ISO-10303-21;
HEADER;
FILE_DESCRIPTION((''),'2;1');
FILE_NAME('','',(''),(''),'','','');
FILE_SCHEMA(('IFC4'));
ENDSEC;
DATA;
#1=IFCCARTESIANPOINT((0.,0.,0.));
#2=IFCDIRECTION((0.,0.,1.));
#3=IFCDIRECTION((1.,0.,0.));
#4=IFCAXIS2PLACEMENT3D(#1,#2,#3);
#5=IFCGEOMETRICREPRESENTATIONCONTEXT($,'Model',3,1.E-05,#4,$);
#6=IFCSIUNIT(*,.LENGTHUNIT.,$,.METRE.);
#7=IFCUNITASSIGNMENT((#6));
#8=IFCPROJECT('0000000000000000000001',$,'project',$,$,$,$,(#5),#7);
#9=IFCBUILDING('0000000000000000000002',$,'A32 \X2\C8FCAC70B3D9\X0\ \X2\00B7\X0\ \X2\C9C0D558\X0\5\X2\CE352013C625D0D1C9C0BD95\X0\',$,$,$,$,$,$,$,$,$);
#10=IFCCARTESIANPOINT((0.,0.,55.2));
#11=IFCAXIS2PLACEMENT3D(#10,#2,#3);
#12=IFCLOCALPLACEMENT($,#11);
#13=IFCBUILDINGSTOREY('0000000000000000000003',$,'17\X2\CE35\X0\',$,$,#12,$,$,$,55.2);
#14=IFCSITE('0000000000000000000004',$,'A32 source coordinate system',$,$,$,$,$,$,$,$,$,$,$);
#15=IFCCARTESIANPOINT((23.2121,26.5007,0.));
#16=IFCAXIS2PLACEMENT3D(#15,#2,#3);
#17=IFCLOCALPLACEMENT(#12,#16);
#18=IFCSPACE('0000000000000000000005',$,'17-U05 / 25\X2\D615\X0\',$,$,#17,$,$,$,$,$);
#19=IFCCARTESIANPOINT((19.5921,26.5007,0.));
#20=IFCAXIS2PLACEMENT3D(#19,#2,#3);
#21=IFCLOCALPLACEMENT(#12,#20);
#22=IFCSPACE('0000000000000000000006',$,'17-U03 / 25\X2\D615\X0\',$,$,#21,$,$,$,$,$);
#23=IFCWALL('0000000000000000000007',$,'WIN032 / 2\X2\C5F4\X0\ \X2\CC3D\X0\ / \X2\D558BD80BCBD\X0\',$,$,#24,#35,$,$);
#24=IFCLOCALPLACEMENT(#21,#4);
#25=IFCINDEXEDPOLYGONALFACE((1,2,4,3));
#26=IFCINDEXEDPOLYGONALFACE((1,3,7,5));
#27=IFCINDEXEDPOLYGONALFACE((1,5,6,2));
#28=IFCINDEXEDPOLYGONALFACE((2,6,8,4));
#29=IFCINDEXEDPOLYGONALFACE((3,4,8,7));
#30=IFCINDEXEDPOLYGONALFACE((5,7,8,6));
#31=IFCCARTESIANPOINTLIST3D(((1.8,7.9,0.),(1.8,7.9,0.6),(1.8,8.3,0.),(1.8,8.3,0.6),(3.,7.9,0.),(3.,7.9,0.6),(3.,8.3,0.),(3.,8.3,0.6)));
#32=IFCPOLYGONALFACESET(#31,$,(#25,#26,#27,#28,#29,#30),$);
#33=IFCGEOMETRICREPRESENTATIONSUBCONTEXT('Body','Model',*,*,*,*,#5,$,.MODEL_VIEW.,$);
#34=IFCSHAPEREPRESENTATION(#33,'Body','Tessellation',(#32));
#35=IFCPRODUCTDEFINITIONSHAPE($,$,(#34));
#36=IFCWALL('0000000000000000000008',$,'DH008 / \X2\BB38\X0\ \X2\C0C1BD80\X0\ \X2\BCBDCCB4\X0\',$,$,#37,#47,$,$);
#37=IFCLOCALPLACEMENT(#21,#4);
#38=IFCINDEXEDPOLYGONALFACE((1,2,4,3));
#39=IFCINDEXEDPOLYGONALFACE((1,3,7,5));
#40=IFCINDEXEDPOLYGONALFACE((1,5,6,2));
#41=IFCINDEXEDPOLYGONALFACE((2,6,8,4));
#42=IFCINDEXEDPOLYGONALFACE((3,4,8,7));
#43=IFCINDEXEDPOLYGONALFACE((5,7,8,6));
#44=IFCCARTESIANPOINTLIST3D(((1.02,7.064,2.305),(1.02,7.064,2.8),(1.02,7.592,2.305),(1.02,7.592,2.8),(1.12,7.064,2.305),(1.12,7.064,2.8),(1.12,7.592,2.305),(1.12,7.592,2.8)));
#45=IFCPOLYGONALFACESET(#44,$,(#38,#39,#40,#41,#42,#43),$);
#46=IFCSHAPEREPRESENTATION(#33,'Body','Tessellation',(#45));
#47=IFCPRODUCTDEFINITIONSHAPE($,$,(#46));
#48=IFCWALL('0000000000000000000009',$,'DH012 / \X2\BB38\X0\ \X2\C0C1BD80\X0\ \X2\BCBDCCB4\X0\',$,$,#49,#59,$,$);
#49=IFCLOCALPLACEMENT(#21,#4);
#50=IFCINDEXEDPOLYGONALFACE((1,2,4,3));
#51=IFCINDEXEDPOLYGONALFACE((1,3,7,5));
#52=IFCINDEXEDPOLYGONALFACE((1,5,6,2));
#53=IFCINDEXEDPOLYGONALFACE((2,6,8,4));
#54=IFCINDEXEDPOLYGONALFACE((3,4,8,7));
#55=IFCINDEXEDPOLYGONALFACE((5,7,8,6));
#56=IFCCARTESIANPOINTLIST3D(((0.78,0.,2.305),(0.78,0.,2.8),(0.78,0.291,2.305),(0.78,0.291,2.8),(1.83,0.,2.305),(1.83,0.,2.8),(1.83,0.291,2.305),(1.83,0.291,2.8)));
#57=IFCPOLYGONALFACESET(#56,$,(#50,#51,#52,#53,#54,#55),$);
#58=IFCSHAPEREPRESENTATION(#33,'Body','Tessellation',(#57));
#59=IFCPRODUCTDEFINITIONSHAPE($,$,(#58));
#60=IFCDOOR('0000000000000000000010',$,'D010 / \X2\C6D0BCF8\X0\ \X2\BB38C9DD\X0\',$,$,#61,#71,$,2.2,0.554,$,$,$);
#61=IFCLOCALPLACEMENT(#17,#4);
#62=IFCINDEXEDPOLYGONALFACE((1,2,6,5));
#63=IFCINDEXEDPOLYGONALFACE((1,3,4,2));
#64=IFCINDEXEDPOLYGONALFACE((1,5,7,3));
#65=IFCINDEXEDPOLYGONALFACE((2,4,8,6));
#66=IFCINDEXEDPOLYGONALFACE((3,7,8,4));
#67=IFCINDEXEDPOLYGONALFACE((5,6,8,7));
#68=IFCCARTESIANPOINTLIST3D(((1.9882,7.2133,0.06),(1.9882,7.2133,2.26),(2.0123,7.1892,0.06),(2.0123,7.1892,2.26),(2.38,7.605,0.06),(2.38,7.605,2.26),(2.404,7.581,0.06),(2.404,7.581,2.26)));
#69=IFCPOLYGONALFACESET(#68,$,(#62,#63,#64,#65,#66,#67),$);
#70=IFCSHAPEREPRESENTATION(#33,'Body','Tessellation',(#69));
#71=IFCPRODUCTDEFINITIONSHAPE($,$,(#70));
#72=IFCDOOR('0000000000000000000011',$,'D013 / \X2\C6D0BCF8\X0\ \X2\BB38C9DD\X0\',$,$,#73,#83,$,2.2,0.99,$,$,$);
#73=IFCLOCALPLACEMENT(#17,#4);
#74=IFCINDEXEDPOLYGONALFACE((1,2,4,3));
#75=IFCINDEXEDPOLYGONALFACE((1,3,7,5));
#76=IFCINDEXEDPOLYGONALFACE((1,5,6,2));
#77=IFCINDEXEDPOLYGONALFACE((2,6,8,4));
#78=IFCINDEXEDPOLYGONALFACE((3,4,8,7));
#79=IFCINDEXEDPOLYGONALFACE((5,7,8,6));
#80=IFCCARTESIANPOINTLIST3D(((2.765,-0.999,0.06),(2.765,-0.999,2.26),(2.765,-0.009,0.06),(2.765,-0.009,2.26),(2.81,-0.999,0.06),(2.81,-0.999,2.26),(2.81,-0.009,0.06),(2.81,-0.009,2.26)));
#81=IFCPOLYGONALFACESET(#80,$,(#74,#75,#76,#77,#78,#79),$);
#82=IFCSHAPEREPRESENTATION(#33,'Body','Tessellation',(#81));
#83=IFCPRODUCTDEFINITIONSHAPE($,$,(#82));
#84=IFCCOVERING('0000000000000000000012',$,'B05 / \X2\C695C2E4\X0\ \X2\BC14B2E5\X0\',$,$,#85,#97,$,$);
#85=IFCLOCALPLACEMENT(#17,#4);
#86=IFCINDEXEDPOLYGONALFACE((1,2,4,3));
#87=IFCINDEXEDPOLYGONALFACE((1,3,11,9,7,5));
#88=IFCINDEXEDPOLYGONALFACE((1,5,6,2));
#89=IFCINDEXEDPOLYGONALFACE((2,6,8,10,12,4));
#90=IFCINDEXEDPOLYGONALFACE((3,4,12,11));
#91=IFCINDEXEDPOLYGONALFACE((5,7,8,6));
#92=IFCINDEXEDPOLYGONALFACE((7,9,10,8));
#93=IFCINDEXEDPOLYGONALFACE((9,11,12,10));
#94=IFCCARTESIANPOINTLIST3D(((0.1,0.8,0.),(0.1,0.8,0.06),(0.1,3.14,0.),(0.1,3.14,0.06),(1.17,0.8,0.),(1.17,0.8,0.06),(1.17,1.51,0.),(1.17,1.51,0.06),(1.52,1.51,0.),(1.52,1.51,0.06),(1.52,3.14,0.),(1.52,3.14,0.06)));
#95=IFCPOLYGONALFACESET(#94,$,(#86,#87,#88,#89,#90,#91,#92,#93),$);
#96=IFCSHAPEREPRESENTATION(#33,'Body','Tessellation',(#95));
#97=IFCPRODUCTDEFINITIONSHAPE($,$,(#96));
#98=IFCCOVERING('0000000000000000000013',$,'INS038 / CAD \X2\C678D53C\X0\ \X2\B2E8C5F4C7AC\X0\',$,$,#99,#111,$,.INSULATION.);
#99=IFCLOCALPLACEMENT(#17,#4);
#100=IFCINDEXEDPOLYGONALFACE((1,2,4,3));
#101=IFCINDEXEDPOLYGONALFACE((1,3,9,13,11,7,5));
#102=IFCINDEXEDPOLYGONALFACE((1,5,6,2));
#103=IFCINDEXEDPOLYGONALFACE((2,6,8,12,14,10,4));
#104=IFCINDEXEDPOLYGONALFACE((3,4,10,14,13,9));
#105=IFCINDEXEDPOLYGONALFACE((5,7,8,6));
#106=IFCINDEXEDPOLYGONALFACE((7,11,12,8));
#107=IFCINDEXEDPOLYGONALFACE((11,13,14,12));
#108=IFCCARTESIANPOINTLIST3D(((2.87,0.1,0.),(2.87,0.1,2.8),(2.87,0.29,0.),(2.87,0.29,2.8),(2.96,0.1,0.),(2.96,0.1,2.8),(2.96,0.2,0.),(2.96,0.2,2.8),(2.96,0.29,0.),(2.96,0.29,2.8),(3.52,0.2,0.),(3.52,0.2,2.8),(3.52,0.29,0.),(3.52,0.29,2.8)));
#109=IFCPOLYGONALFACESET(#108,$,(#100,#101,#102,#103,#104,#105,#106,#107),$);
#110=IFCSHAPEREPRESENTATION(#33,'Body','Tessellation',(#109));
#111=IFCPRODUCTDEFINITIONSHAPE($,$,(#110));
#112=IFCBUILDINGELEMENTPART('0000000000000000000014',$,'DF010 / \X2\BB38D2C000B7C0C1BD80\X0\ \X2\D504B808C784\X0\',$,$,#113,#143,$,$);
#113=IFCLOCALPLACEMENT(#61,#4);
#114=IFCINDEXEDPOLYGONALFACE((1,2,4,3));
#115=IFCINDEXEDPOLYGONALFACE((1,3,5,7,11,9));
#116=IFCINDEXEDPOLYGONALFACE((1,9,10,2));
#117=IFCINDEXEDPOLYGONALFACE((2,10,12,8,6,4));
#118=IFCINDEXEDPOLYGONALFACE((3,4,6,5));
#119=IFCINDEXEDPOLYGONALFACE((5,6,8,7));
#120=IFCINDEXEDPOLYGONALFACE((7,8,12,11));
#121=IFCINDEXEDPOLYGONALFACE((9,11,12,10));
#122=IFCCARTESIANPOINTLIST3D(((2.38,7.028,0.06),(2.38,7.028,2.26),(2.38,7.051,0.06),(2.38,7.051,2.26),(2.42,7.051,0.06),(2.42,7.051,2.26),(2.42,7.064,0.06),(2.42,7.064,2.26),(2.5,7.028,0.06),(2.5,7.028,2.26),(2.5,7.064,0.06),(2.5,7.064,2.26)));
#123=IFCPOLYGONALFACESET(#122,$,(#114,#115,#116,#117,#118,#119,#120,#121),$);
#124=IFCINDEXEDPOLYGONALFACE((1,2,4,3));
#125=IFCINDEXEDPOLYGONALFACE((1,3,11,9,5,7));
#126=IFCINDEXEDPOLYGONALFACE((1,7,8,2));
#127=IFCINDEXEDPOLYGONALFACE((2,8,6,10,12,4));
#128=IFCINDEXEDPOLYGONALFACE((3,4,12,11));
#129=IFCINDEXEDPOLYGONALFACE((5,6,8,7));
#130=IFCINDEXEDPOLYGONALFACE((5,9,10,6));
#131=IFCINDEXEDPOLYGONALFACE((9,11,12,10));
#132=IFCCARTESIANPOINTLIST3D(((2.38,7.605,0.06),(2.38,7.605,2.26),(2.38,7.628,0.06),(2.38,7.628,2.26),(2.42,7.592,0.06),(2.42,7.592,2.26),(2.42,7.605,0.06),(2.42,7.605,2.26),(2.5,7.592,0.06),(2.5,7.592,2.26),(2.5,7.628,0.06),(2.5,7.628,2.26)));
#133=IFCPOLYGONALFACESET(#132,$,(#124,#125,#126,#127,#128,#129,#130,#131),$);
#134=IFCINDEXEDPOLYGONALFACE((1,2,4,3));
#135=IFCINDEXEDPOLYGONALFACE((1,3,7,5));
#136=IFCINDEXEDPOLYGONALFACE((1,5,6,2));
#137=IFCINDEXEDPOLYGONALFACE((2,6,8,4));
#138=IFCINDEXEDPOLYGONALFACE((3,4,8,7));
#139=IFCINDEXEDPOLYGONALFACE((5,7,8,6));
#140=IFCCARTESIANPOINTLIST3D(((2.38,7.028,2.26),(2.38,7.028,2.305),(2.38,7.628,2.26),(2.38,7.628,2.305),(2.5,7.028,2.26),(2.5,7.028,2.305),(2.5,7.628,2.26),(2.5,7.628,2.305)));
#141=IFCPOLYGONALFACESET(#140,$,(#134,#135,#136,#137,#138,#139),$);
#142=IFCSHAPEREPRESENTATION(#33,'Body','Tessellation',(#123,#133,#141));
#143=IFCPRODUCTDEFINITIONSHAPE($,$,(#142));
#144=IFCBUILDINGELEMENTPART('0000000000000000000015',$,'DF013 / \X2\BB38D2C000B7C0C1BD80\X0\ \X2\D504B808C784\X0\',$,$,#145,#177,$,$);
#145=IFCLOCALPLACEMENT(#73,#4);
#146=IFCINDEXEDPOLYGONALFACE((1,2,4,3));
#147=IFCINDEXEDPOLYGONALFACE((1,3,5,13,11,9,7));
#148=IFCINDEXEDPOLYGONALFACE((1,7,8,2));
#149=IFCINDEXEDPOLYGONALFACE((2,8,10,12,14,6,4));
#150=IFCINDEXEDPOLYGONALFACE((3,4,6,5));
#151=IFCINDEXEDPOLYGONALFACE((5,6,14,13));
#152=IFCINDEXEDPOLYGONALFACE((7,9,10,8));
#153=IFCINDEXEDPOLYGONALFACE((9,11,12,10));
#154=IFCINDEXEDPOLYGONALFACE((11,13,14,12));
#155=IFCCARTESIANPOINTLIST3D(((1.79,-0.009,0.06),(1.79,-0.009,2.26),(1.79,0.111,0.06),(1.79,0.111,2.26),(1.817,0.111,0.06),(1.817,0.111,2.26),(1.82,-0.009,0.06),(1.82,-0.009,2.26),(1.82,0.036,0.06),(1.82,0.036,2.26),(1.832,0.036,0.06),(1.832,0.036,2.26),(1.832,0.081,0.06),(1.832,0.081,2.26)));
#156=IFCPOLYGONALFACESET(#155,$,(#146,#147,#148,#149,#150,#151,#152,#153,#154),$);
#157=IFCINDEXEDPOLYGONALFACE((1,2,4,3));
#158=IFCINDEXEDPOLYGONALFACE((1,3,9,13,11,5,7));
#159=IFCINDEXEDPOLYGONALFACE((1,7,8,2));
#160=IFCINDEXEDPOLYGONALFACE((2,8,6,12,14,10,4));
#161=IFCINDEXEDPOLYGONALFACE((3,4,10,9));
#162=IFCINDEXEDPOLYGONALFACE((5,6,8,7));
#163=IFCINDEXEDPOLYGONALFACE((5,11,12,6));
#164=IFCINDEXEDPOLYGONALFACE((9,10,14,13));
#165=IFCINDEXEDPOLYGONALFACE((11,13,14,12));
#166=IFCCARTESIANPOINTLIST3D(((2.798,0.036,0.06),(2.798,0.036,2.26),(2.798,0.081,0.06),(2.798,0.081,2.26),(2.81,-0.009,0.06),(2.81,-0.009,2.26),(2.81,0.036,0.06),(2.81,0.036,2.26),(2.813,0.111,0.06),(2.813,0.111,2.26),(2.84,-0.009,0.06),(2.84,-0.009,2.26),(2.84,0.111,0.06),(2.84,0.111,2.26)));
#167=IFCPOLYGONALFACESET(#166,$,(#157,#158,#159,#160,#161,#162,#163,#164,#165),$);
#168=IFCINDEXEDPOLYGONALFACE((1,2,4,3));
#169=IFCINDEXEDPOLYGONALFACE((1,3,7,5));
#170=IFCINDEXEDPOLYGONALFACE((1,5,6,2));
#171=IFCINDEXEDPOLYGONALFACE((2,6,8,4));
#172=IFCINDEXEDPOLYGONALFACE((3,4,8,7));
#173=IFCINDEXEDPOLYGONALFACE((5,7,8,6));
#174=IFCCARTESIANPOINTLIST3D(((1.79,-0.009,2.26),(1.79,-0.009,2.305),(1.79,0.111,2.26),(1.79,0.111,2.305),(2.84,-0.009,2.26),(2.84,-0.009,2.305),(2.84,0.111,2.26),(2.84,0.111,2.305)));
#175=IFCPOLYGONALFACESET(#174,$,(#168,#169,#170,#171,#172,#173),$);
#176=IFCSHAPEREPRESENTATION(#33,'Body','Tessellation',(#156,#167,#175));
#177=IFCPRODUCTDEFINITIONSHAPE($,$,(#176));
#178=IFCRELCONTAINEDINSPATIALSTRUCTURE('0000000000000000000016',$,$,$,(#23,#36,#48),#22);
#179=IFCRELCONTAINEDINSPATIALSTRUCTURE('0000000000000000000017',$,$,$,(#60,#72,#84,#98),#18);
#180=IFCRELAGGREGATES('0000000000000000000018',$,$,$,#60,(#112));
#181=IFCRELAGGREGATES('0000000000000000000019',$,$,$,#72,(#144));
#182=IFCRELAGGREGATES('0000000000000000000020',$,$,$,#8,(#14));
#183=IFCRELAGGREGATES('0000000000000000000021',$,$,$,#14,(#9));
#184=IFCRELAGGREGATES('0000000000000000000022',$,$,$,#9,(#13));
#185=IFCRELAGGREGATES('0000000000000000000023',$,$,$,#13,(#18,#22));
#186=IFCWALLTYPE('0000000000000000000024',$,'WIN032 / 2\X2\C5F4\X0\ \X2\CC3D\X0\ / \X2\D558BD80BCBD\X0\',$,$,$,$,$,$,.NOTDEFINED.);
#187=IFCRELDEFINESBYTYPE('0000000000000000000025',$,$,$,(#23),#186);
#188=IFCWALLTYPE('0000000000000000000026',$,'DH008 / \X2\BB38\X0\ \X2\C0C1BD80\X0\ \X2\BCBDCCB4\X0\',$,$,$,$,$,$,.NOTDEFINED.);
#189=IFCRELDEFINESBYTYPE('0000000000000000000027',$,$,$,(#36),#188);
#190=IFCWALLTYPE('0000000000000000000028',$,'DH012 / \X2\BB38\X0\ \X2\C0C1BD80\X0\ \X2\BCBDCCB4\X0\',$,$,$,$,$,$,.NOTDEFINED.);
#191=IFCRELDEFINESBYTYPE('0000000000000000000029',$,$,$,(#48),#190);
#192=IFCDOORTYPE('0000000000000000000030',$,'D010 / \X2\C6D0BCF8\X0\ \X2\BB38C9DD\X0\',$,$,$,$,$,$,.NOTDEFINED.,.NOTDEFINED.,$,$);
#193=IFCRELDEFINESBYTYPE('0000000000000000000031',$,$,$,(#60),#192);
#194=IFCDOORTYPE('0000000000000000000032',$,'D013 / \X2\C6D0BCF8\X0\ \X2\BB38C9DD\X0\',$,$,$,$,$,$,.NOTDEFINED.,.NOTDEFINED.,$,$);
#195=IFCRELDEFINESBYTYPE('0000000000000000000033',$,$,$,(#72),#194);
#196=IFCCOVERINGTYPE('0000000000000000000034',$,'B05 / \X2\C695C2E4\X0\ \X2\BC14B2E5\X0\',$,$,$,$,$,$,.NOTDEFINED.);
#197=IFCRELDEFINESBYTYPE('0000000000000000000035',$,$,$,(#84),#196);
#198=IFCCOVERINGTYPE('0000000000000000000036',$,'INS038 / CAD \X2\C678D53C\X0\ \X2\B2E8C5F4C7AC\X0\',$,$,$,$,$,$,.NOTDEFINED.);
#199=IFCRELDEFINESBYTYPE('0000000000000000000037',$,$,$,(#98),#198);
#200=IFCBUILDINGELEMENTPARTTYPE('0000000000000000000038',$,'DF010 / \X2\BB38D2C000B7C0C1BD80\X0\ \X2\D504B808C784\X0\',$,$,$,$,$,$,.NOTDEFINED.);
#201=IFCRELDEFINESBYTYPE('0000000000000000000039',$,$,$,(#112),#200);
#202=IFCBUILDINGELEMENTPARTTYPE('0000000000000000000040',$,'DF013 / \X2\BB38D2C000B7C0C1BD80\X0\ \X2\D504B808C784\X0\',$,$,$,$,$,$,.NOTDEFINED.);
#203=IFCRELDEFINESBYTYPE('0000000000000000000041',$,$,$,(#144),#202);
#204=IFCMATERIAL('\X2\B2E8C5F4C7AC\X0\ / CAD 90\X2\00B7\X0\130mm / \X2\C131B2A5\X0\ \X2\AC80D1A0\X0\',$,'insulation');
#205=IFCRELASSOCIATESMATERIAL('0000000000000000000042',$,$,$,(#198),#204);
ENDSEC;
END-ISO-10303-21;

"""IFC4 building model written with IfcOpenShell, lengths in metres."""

from ifc_helpers import new_model, si_unit, frame, origin, origin_with_axes, place, context, subcontext, project, spatial, polyline, outline, extrude, source, transform, mapped, material, type_object, type_shapes, element, aggregate, save


model = new_model("IFC4")

# Units and contexts
model_context = context("Model", 3, precision=1e-05, world=origin_with_axes())
body_context = subcontext(model_context, "Body", "Model", "MODEL_VIEW")
ifc_project = project(units=[si_unit("LENGTHUNIT", "METRE")], contexts=[model_context])

# Site, building, storey, space
storey_placement = place(None, frame((0.0, 0.0, 55.2), z_axis=(0.0, 0.0, 1.0), x_axis=(1.0, 0.0, 0.0)))
space_1_placement = place(storey_placement, frame((23.2121, 26.5007, 0.0), z_axis=(0.0, 0.0, 1.0), x_axis=(1.0, 0.0, 0.0)))
site = spatial("IfcSite", under=ifc_project, Name="A32 source coordinate system")
building = spatial("IfcBuilding", under=site, Name="A32 주거동 · 지하5층–옥탑지붕")
storey = spatial("IfcBuildingStorey", under=building, at=storey_placement, Name="17층", Elevation=55.2)
space_1 = spatial("IfcSpace", under=storey, at=space_1_placement, Name="17-U05 / 25형")

# Shared definitions
space_2_placement = place(storey_placement, frame((19.5921, 26.5007, 0.0), z_axis=(0.0, 0.0, 1.0), x_axis=(1.0, 0.0, 0.0)))
space_2 = spatial("IfcSpace", under=storey, at=space_2_placement, Name="17-U03 / 25형")

# Walls
wall_type_1 = type_object("IfcWallType", Name="WIN032 / 2열 창 / 하부벽", PredefinedType="NOTDEFINED")
shared_shape_1 = source(origin(), body_context, "Body", "SweptSolid", [
    extrude(outline(polyline([(3.0, 7.9), (1.8, 7.9), (1.8, 8.3), (3.0, 8.3), (3.0, 7.9)])), origin(), (0.0, 0.0, 1.0), 0.6),
])
type_shapes(wall_type_1, [shared_shape_1])
wall_1_placement = place(space_2_placement, origin_with_axes())
element("IfcWall", 1, at=wall_1_placement, inside=space_2, type_object=wall_type_1, Name="WIN032 / 2열 창 / 하부벽", context=body_context, shape_type="MappedRepresentation", body=[
    mapped(shared_shape_1, transform((0.0, 0.0, 0.0), scale=1.0)),
])
wall_type_2 = type_object("IfcWallType", Name="DH008 / 문 상부 벽체", PredefinedType="NOTDEFINED")
shared_shape_2 = source(origin(), body_context, "Body", "SweptSolid", [
    extrude(outline(polyline([(1.12, 7.064), (1.02, 7.064), (1.02, 7.592), (1.12, 7.592), (1.12, 7.064)])), frame((0.0, 0.0, 2.305)), (0.0, 0.0, 1.0), 0.495),
])
type_shapes(wall_type_2, [shared_shape_2])
wall_2_placement = place(space_2_placement, origin_with_axes())
element("IfcWall", 2, at=wall_2_placement, inside=space_2, type_object=wall_type_2, Name="DH008 / 문 상부 벽체", context=body_context, shape_type="MappedRepresentation", body=[
    mapped(shared_shape_2, transform((0.0, 0.0, 0.0), scale=1.0)),
])
wall_type_3 = type_object("IfcWallType", Name="DH012 / 문 상부 벽체", PredefinedType="NOTDEFINED")
shared_shape_3 = source(origin(), body_context, "Body", "SweptSolid", [
    extrude(outline(polyline([(0.78, 0.0), (0.78, 0.291), (1.83, 0.291), (1.83, 0.0), (0.78, 0.0)])), frame((0.0, 0.0, 2.305)), (0.0, 0.0, 1.0), 0.495),
])
type_shapes(wall_type_3, [shared_shape_3])
wall_3_placement = place(space_2_placement, origin_with_axes())
element("IfcWall", 3, at=wall_3_placement, inside=space_2, type_object=wall_type_3, Name="DH012 / 문 상부 벽체", context=body_context, shape_type="MappedRepresentation", body=[
    mapped(shared_shape_3, transform((0.0, 0.0, 0.0), scale=1.0)),
])

# Doors
door_type_1 = type_object("IfcDoorType", Name="D010 / 원본 문짝", OperationType="NOTDEFINED", PredefinedType="NOTDEFINED")
shared_shape_4 = source(origin(), body_context, "Body", "SweptSolid", [
    extrude(outline(polyline([(2.0123, 7.1892), (1.9882, 7.2133), (2.38, 7.605), (2.404, 7.581), (2.0123, 7.1892)])), frame((0.0, 0.0, 0.06)), (0.0, 0.0, 1.0), 2.2),
])
type_shapes(door_type_1, [shared_shape_4])
door_1_placement = place(space_1_placement, origin_with_axes())
door_1 = element("IfcDoor", 4, at=door_1_placement, inside=space_1, type_object=door_type_1, Name="D010 / 원본 문짝", OverallHeight=2.2, OverallWidth=0.554, context=body_context, shape_type="MappedRepresentation", body=[
    mapped(shared_shape_4, transform((0.0, 0.0, 0.0), scale=1.0)),
])
door_type_2 = type_object("IfcDoorType", Name="D013 / 원본 문짝", OperationType="NOTDEFINED", PredefinedType="NOTDEFINED")
shared_shape_5 = source(origin(), body_context, "Body", "SweptSolid", [
    extrude(outline(polyline([(2.81, -0.009), (2.81, -0.999), (2.765, -0.999), (2.765, -0.009), (2.81, -0.009)])), frame((0.0, 0.0, 0.06)), (0.0, 0.0, 1.0), 2.2),
])
type_shapes(door_type_2, [shared_shape_5])
door_2_placement = place(space_1_placement, origin_with_axes())
door_2 = element("IfcDoor", 5, at=door_2_placement, inside=space_1, type_object=door_type_2, Name="D013 / 원본 문짝", OverallHeight=2.2, OverallWidth=0.99, context=body_context, shape_type="MappedRepresentation", body=[
    mapped(shared_shape_5, transform((0.0, 0.0, 0.0), scale=1.0)),
])

# Coverings
covering_type_1 = type_object("IfcCoveringType", Name="B05 / 욕실 바닥", PredefinedType="NOTDEFINED")
shared_shape_6 = source(origin(), body_context, "Body", "SweptSolid", [
    extrude(outline(polyline([(0.1, 3.14), (1.52, 3.14), (1.52, 1.51), (1.17, 1.51), (1.17, 0.8), (0.1, 0.8), (0.1, 3.14)])), origin(), (0.0, 0.0, 1.0), 0.06),
])
type_shapes(covering_type_1, [shared_shape_6])
covering_1_placement = place(space_1_placement, origin_with_axes())
element("IfcCovering", 6, at=covering_1_placement, inside=space_1, type_object=covering_type_1, Name="B05 / 욕실 바닥", context=body_context, shape_type="MappedRepresentation", body=[
    mapped(shared_shape_6, transform((0.0, 0.0, 0.0), scale=1.0)),
])
ifc_material = material(Name="단열재 / CAD 90·130mm / 성능 검토", Category="insulation")
covering_type_2 = type_object("IfcCoveringType", Name="INS038 / CAD 외피 단열재", PredefinedType="NOTDEFINED", material=ifc_material)
shared_shape_7 = source(origin(), body_context, "Body", "SweptSolid", [
    extrude(outline(polyline([(2.96, 0.2), (2.96, 0.1), (2.87, 0.1), (2.87, 0.29), (2.96, 0.29), (3.52, 0.29), (3.52, 0.2), (2.96, 0.2)])), origin(), (0.0, 0.0, 1.0), 2.8),
])
type_shapes(covering_type_2, [shared_shape_7])
covering_2_placement = place(space_1_placement, origin_with_axes())
element("IfcCovering", 7, at=covering_2_placement, inside=space_1, type_object=covering_type_2, Name="INS038 / CAD 외피 단열재", PredefinedType="INSULATION", context=body_context, shape_type="MappedRepresentation", body=[
    mapped(shared_shape_7, transform((0.0, 0.0, 0.0), scale=1.0)),
])

# Building element parts
building_element_part_type_1 = type_object("IfcBuildingElementPartType", Name="DF010 / 문틀·상부 프레임", PredefinedType="NOTDEFINED")
shared_shape_8 = source(origin(), body_context, "Body", "SweptSolid", [
    extrude(outline(polyline([(2.38, 7.028), (2.38, 7.051), (2.42, 7.051), (2.42, 7.064), (2.5, 7.064), (2.5, 7.028), (2.38, 7.028)])), frame((0.0, 0.0, 0.06)), (0.0, 0.0, 1.0), 2.2),
    extrude(outline(polyline([(2.5, 7.592), (2.42, 7.592), (2.42, 7.605), (2.38, 7.605), (2.38, 7.628), (2.5, 7.628), (2.5, 7.592)])), frame((0.0, 0.0, 0.06)), (0.0, 0.0, 1.0), 2.2),
    extrude(outline(polyline([(2.38, 7.028), (2.38, 7.628), (2.5, 7.628), (2.5, 7.028), (2.38, 7.028)])), frame((0.0, 0.0, 2.26)), (0.0, 0.0, 1.0), 0.045),
])
type_shapes(building_element_part_type_1, [shared_shape_8])
building_element_part_1_placement = place(door_1_placement, origin_with_axes())
building_element_part_1 = element("IfcBuildingElementPart", 8, at=building_element_part_1_placement, type_object=building_element_part_type_1, Name="DF010 / 문틀·상부 프레임", context=body_context, shape_type="MappedRepresentation", body=[
    mapped(shared_shape_8, transform((0.0, 0.0, 0.0), scale=1.0)),
])
aggregate(door_1, [building_element_part_1])
building_element_part_type_2 = type_object("IfcBuildingElementPartType", Name="DF013 / 문틀·상부 프레임", PredefinedType="NOTDEFINED")
shared_shape_9 = source(origin(), body_context, "Body", "SweptSolid", [
    extrude(outline(polyline([(1.79, 0.111), (1.817, 0.111), (1.832, 0.081), (1.832, 0.036), (1.82, 0.036), (1.82, -0.009), (1.79, -0.009), (1.79, 0.111)])), frame((0.0, 0.0, 0.06)), (0.0, 0.0, 1.0), 2.2),
    extrude(outline(polyline([(2.81, -0.009), (2.81, 0.036), (2.798, 0.036), (2.798, 0.081), (2.813, 0.111), (2.84, 0.111), (2.84, -0.009), (2.81, -0.009)])), frame((0.0, 0.0, 0.06)), (0.0, 0.0, 1.0), 2.2),
    extrude(outline(polyline([(1.79, -0.009), (1.79, 0.111), (2.84, 0.111), (2.84, -0.009), (1.79, -0.009)])), frame((0.0, 0.0, 2.26)), (0.0, 0.0, 1.0), 0.045),
])
type_shapes(building_element_part_type_2, [shared_shape_9])
building_element_part_2_placement = place(door_2_placement, origin_with_axes())
building_element_part_2 = element("IfcBuildingElementPart", 9, at=building_element_part_2_placement, type_object=building_element_part_type_2, Name="DF013 / 문틀·상부 프레임", context=body_context, shape_type="MappedRepresentation", body=[
    mapped(shared_shape_9, transform((0.0, 0.0, 0.0), scale=1.0)),
])
aggregate(door_2, [building_element_part_2])

save(model, "model.ifc")
